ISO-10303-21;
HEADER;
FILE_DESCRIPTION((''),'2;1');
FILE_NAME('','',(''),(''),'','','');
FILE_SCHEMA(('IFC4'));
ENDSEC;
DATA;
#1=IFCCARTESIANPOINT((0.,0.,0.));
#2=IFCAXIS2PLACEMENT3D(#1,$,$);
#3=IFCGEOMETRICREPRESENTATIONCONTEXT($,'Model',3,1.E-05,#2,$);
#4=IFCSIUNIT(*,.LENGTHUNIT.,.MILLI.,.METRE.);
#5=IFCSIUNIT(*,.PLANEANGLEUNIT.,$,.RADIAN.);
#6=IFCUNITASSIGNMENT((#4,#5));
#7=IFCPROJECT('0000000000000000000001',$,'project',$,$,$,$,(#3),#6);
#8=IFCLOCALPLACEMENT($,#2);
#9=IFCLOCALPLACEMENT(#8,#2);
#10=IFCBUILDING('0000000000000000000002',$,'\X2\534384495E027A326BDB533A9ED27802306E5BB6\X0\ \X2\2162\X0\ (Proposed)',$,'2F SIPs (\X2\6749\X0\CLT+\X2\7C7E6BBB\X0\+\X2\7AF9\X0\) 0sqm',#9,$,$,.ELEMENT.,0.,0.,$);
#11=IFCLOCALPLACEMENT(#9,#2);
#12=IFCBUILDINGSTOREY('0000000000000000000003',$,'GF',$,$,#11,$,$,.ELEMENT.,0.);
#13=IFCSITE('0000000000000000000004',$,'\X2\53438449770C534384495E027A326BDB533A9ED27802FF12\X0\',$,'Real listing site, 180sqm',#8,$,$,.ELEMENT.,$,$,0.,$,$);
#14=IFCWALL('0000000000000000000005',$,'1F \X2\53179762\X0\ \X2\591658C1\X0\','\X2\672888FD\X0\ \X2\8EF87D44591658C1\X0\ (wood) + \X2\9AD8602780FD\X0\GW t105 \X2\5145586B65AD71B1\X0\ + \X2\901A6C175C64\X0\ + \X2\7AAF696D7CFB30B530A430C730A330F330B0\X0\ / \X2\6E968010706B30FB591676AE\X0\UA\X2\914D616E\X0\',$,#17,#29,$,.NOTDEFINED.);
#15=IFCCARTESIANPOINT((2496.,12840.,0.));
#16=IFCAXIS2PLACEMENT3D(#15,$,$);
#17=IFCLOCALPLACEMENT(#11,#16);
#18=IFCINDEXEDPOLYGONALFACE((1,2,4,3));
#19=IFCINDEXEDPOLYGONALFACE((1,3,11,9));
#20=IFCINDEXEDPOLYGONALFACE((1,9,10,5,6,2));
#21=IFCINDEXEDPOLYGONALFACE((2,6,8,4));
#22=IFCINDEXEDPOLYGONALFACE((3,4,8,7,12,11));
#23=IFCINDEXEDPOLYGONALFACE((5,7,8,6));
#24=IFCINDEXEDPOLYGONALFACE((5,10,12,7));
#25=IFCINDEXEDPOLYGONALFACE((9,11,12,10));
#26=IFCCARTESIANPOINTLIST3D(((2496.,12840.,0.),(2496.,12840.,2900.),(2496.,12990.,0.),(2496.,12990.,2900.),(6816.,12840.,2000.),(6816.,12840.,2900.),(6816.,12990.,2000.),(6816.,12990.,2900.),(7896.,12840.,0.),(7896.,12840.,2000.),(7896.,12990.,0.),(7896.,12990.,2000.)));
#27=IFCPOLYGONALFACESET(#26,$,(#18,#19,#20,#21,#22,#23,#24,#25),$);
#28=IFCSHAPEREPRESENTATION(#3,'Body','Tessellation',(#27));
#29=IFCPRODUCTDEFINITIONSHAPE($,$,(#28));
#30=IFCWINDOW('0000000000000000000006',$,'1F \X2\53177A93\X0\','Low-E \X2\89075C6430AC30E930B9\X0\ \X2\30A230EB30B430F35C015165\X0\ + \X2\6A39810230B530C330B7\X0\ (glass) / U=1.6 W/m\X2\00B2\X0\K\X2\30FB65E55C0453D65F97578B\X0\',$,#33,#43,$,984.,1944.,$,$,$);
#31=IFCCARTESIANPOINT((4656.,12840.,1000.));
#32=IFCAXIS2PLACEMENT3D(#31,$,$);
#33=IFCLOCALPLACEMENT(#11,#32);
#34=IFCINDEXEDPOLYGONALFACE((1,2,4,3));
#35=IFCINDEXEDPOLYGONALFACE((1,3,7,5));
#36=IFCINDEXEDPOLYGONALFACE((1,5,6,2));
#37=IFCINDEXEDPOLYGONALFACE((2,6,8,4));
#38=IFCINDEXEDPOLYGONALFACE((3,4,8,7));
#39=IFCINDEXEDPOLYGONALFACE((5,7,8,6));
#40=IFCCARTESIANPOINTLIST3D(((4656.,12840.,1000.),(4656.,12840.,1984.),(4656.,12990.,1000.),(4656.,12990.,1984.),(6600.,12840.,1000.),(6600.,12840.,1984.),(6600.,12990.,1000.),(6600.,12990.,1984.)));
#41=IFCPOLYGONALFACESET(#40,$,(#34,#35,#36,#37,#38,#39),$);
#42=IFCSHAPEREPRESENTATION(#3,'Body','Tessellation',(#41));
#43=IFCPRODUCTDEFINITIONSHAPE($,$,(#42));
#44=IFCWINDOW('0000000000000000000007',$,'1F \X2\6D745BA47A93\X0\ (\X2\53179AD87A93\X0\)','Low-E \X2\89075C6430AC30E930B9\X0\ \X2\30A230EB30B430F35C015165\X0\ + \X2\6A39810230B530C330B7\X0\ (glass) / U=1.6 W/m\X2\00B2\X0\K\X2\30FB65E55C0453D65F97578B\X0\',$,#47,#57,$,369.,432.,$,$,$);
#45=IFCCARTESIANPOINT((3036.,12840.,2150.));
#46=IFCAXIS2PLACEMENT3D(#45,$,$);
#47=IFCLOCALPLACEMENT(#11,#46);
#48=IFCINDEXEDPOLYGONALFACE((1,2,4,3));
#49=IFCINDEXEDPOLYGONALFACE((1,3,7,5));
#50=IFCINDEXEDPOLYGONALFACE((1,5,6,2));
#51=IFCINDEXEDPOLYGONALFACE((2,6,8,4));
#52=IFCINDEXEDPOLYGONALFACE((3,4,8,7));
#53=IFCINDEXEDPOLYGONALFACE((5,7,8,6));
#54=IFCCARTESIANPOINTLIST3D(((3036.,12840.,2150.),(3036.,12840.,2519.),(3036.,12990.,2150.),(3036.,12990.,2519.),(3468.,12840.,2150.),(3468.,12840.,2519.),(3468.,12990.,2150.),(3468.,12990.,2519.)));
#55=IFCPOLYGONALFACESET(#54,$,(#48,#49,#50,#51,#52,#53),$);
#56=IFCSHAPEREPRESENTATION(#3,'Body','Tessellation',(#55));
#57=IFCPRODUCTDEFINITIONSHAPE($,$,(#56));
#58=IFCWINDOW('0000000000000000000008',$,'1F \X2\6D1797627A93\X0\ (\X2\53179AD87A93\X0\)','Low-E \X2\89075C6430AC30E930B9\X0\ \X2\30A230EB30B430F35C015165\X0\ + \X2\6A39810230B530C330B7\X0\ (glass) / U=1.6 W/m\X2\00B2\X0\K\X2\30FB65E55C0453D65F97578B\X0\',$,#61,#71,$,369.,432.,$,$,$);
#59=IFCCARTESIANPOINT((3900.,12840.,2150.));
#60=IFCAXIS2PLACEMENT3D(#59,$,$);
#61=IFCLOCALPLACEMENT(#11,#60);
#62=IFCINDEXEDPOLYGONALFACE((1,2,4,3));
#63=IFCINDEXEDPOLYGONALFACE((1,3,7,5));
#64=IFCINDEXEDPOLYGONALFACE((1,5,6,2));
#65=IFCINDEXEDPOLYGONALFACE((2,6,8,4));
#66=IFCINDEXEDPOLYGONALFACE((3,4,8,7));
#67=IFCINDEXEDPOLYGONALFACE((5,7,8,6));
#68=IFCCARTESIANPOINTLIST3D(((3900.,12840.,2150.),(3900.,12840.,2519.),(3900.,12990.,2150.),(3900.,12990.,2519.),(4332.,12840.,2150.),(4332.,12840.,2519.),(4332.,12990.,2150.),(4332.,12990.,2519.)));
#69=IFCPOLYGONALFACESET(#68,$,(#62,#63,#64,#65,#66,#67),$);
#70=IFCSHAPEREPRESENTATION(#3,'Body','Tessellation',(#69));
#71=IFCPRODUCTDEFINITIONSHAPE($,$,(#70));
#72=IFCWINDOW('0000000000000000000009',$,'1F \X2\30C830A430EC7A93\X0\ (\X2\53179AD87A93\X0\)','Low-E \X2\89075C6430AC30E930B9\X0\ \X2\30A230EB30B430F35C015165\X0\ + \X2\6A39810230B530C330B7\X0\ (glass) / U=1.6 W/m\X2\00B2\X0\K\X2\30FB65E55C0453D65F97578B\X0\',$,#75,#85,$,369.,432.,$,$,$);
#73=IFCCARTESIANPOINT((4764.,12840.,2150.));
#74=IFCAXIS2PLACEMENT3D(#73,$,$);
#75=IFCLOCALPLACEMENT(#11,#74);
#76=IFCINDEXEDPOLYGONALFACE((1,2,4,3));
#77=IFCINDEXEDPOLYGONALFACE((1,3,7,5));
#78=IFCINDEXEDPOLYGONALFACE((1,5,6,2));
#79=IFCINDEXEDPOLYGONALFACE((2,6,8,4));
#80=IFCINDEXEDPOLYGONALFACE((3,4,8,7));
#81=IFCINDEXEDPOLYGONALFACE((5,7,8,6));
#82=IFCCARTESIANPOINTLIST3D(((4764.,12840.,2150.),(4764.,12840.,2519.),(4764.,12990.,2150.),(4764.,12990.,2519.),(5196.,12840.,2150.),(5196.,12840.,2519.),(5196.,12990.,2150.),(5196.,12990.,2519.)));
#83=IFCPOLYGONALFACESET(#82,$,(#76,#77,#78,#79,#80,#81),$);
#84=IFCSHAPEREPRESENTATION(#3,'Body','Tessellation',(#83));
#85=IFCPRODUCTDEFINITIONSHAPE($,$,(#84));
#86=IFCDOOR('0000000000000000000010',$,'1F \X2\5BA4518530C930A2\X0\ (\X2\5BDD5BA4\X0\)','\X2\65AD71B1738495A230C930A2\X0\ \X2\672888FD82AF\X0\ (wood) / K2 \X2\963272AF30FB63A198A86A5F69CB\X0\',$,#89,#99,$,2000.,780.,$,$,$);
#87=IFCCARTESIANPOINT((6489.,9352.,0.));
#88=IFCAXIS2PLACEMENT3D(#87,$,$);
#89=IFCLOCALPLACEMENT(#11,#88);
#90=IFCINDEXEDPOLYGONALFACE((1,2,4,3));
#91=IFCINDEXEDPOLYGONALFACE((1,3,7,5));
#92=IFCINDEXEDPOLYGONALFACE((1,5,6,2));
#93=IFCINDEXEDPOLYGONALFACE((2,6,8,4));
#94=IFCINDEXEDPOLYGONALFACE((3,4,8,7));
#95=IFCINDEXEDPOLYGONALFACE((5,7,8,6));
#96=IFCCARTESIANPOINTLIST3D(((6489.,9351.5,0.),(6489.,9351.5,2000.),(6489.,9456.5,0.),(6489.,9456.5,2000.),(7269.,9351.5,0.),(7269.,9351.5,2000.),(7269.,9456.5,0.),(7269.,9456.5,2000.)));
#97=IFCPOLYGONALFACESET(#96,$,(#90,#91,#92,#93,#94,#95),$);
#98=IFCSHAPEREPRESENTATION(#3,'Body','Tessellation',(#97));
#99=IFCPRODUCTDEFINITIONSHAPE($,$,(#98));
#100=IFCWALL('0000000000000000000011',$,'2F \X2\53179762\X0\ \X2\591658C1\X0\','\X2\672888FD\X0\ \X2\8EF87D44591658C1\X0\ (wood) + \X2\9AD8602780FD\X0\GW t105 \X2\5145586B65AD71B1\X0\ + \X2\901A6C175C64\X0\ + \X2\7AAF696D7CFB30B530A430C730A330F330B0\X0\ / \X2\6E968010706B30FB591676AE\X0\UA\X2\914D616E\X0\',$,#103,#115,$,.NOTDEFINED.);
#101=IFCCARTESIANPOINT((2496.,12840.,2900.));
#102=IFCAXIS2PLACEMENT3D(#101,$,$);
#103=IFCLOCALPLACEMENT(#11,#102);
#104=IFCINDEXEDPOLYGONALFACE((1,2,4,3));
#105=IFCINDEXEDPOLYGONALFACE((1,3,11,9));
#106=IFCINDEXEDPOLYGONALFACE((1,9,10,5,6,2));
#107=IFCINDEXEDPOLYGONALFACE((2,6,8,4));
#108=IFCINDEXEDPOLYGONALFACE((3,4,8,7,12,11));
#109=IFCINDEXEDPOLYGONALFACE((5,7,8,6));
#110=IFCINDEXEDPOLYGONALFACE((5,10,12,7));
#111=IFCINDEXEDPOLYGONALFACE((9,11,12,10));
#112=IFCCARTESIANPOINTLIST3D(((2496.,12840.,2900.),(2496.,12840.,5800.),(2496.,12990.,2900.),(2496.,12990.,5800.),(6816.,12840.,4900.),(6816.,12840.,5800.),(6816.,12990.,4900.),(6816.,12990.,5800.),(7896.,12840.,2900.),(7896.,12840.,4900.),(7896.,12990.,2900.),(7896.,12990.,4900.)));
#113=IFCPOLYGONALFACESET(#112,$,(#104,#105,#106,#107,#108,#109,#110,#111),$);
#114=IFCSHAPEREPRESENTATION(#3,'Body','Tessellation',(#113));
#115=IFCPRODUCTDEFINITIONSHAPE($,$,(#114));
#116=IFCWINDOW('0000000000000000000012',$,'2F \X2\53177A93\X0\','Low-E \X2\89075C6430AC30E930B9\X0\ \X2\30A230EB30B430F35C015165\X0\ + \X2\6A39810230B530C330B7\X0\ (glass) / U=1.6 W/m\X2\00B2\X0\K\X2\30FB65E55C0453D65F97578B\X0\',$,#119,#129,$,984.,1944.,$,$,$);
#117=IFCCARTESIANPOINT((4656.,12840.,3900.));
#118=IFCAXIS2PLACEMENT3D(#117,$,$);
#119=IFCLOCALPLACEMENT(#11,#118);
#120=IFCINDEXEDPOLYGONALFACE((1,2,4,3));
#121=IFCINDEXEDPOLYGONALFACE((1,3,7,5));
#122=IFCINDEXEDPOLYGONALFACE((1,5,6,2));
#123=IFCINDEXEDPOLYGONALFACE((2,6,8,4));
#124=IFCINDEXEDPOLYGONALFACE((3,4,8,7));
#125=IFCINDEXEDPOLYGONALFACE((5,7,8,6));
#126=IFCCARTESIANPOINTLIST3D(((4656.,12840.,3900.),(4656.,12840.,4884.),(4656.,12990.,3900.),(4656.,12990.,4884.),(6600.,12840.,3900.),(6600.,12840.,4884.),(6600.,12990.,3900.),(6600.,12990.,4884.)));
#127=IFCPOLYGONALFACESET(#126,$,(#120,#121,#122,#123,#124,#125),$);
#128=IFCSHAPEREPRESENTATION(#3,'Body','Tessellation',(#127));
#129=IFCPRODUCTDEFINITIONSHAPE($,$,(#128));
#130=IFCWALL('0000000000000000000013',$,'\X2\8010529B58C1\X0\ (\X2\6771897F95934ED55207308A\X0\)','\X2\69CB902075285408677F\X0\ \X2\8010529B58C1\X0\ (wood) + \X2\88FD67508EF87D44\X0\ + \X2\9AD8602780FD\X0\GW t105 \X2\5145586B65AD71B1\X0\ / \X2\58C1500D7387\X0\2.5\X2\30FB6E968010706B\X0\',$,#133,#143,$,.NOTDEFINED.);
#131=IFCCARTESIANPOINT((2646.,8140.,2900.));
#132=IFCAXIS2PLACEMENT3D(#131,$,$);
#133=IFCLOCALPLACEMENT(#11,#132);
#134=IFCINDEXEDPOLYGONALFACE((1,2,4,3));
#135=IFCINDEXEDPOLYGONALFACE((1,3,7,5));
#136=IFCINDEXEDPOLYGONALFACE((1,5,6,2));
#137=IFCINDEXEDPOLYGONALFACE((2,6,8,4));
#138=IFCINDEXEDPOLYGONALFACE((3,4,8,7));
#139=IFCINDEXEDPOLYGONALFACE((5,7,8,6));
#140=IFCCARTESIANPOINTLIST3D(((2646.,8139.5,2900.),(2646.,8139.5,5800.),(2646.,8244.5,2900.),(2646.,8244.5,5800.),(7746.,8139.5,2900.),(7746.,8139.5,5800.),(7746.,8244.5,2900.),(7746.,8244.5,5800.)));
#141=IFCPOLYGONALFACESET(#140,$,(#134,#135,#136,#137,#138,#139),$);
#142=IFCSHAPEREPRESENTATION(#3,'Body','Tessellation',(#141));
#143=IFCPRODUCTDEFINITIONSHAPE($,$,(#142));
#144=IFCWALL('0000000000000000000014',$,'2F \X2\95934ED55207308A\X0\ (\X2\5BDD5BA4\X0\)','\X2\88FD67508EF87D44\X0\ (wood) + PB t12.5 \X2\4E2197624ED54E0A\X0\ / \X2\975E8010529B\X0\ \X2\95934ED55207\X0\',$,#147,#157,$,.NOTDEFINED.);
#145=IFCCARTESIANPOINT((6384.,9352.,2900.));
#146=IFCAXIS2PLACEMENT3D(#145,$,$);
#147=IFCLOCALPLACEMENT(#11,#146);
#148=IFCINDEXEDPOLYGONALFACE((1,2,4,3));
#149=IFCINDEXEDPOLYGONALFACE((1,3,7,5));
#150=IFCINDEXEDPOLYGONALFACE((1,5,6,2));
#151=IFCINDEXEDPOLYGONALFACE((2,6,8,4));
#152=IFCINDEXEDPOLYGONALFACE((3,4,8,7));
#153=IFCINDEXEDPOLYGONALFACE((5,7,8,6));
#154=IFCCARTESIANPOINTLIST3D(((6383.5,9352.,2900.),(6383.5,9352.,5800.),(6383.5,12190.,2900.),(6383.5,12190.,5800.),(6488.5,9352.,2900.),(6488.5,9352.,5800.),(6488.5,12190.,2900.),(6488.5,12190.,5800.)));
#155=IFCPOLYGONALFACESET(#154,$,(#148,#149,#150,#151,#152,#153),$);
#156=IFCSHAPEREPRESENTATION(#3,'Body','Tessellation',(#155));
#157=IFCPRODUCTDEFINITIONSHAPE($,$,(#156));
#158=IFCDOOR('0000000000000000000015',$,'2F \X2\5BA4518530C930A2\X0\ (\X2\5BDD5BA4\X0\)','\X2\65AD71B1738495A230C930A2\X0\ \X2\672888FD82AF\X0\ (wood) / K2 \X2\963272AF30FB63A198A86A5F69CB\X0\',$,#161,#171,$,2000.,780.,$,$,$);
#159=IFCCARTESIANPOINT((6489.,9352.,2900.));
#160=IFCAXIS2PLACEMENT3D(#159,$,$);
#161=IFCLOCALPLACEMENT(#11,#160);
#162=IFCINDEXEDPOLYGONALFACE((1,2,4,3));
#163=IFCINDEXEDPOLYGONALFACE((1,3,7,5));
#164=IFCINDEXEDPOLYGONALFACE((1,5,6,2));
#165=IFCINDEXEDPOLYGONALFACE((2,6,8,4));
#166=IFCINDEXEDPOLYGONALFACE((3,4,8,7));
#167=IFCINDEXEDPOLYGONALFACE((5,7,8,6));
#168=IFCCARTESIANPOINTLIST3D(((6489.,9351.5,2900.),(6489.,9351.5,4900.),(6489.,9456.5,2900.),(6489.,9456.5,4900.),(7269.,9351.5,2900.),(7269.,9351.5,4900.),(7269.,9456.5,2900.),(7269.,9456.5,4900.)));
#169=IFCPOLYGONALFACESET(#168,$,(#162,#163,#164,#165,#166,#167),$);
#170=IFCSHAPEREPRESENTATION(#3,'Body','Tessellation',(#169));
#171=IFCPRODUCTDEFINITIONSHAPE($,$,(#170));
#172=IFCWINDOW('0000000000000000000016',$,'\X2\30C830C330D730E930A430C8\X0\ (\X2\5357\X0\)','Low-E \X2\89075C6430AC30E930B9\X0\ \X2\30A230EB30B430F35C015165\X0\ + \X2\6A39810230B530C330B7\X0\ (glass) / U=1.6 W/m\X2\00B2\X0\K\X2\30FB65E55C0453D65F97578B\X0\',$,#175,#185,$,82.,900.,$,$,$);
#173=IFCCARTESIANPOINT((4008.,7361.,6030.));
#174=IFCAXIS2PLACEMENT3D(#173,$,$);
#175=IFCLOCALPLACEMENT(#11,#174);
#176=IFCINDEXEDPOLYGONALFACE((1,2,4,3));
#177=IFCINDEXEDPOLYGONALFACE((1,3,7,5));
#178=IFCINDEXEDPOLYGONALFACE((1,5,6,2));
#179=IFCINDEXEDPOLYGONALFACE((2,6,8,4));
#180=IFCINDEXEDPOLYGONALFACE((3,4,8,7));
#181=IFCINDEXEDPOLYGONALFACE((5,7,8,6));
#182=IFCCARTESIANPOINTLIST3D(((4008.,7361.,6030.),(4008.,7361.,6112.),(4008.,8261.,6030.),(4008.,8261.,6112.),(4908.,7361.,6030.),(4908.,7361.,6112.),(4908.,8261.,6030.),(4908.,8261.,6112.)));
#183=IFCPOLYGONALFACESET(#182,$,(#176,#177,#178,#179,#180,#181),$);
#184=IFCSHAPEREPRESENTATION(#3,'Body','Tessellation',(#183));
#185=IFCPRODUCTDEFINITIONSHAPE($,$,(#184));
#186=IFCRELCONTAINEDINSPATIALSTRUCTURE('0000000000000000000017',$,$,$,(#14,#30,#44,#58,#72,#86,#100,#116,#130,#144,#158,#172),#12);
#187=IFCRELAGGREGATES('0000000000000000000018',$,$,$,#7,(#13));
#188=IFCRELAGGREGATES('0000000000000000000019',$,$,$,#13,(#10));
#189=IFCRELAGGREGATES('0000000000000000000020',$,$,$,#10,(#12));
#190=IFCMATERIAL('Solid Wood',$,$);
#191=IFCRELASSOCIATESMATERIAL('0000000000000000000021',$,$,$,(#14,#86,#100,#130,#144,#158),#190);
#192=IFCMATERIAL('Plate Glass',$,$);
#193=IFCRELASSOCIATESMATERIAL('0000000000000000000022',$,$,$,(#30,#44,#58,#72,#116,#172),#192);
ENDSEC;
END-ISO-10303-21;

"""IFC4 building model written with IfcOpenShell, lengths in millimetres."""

from ifc_helpers import new_model, si_unit, frame, frame_2d, origin, place, context, project, spatial, rectangle, extrude, material, element, fill, save


model = new_model("IFC4")

# Units and contexts
model_context = context("Model", 3, precision=1e-05, world=origin())
ifc_project = project(units=[si_unit("LENGTHUNIT", "METRE", prefix="MILLI"), si_unit("PLANEANGLEUNIT", "RADIAN")], contexts=[model_context])

# Site, building, storey
site_placement = place(None, origin())
site = spatial("IfcSite", under=ifc_project, at=site_placement, Name="千葉県千葉市稲毛区黒砂２", ObjectType="Real listing site, 180sqm", CompositionType="ELEMENT", RefElevation=0.0)
building_placement = place(site_placement, origin())
building = spatial("IfcBuilding", under=site, at=building_placement, Name="千葉市稲毛区黒砂の家 Ⅲ (Proposed)", ObjectType="2F SIPs (杉CLT+籾殻+竹) 0sqm", CompositionType="ELEMENT", ElevationOfRefHeight=0.0, ElevationOfTerrain=0.0)
storey_placement = place(building_placement, origin())
storey = spatial("IfcBuildingStorey", under=building, at=storey_placement, Name="GF", CompositionType="ELEMENT", Elevation=0.0)

# Wall, openings, windows
ifc_material_1 = material(Name="Solid Wood")
wall_1_placement = place(storey_placement, frame((2496.0, 12840.0, 0.0)))
wall_1 = element("IfcWall", 1, at=wall_1_placement, inside=storey, material=ifc_material_1, Name="1F 北面 外壁", Description="木製 軸組外壁 (wood) + 高性能GW t105 充填断熱 + 通気層 + 窯業系サイディング / 準耐火・外皮UA配慮", PredefinedType="NOTDEFINED", context=model_context, shape_type="SweptSolid", body=[
    extrude(rectangle(XDim=5400.0, YDim=150.0, at=frame_2d((2700.0, 75.0))), frame((2496.0, 12840.0, 0.0)), (0.0, 0.0, 1.0), 2900.0),
])
opening_1_placement = place(storey_placement, frame((4656.0, 12840.0, 1000.0)))
opening_1 = element("IfcOpeningElement", 2, at=opening_1_placement, cuts=wall_1, PredefinedType="NOTDEFINED", context=model_context, shape_type="SweptSolid", body=[
    extrude(rectangle(XDim=1944.0, YDim=150.0, at=frame_2d((972.0, 75.0))), frame((4656.0, 12840.0, 1000.0)), (0.0, 0.0, 1.0), 984.0),
])
opening_2_placement = place(storey_placement, frame((3036.0, 12840.0, 2150.0)))
opening_2 = element("IfcOpeningElement", 3, at=opening_2_placement, cuts=wall_1, PredefinedType="NOTDEFINED", context=model_context, shape_type="SweptSolid", body=[
    extrude(rectangle(XDim=432.0, YDim=150.0, at=frame_2d((216.0, 75.0))), frame((3036.0, 12840.0, 2150.0)), (0.0, 0.0, 1.0), 369.0),
])
opening_3_placement = place(storey_placement, frame((3900.0, 12840.0, 2150.0)))
opening_3 = element("IfcOpeningElement", 4, at=opening_3_placement, cuts=wall_1, PredefinedType="NOTDEFINED", context=model_context, shape_type="SweptSolid", body=[
    extrude(rectangle(XDim=432.0, YDim=150.0, at=frame_2d((216.0, 75.0))), frame((3900.0, 12840.0, 2150.0)), (0.0, 0.0, 1.0), 369.0),
])
opening_4_placement = place(storey_placement, frame((4764.0, 12840.0, 2150.0)))
opening_4 = element("IfcOpeningElement", 5, at=opening_4_placement, cuts=wall_1, PredefinedType="NOTDEFINED", context=model_context, shape_type="SweptSolid", body=[
    extrude(rectangle(XDim=432.0, YDim=150.0, at=frame_2d((216.0, 75.0))), frame((4764.0, 12840.0, 2150.0)), (0.0, 0.0, 1.0), 369.0),
])
ifc_material_2 = material(Name="Plate Glass")
window_1_placement = place(storey_placement, frame((4656.0, 12840.0, 1000.0)))
window_1 = element("IfcWindow", 6, at=window_1_placement, inside=storey, material=ifc_material_2, Name="1F 北窓", Description="Low-E 複層ガラス アルゴン封入 + 樹脂サッシ (glass) / U=1.6 W/m²K・日射取得型", OverallHeight=984.0, OverallWidth=1944.0, context=model_context, shape_type="SweptSolid", body=[
    extrude(rectangle(XDim=1944.0, YDim=150.0, at=frame_2d((972.0, 75.0))), frame((4656.0, 12840.0, 1000.0)), (0.0, 0.0, 1.0), 984.0),
])
fill(opening_1, window_1)
window_2_placement = place(storey_placement, frame((3036.0, 12840.0, 2150.0)))
window_2 = element("IfcWindow", 7, at=window_2_placement, inside=storey, material=ifc_material_2, Name="1F 浴室窓 (北高窓)", Description="Low-E 複層ガラス アルゴン封入 + 樹脂サッシ (glass) / U=1.6 W/m²K・日射取得型", OverallHeight=369.0, OverallWidth=432.0, context=model_context, shape_type="SweptSolid", body=[
    extrude(rectangle(XDim=432.0, YDim=150.0, at=frame_2d((216.0, 75.0))), frame((3036.0, 12840.0, 2150.0)), (0.0, 0.0, 1.0), 369.0),
])
fill(opening_2, window_2)
window_3_placement = place(storey_placement, frame((3900.0, 12840.0, 2150.0)))
window_3 = element("IfcWindow", 8, at=window_3_placement, inside=storey, material=ifc_material_2, Name="1F 洗面窓 (北高窓)", Description="Low-E 複層ガラス アルゴン封入 + 樹脂サッシ (glass) / U=1.6 W/m²K・日射取得型", OverallHeight=369.0, OverallWidth=432.0, context=model_context, shape_type="SweptSolid", body=[
    extrude(rectangle(XDim=432.0, YDim=150.0, at=frame_2d((216.0, 75.0))), frame((3900.0, 12840.0, 2150.0)), (0.0, 0.0, 1.0), 369.0),
])
fill(opening_3, window_3)
window_4_placement = place(storey_placement, frame((4764.0, 12840.0, 2150.0)))
window_4 = element("IfcWindow", 9, at=window_4_placement, inside=storey, material=ifc_material_2, Name="1F トイレ窓 (北高窓)", Description="Low-E 複層ガラス アルゴン封入 + 樹脂サッシ (glass) / U=1.6 W/m²K・日射取得型", OverallHeight=369.0, OverallWidth=432.0, context=model_context, shape_type="SweptSolid", body=[
    extrude(rectangle(XDim=432.0, YDim=150.0, at=frame_2d((216.0, 75.0))), frame((4764.0, 12840.0, 2150.0)), (0.0, 0.0, 1.0), 369.0),
])
fill(opening_4, window_4)

# Door
door_1_placement = place(storey_placement, frame((6489.0, 9352.0, 0.0)))
element("IfcDoor", 10, at=door_1_placement, inside=storey, material=ifc_material_1, Name="1F 室内ドア (寝室)", Description="断熱玄関ドア 木製芯 (wood) / K2 防犯・採風機構", OverallHeight=2000.0, OverallWidth=780.0, context=model_context, shape_type="SweptSolid", body=[
    extrude(rectangle(XDim=780.0, YDim=105.0, at=frame_2d((390.0, 52.0))), frame((6489.0, 9352.0, 0.0)), (0.0, 0.0, 1.0), 2000.0),
])

# Wall, opening, window
wall_2_placement = place(storey_placement, frame((2496.0, 12840.0, 2900.0)))
wall_2 = element("IfcWall", 11, at=wall_2_placement, inside=storey, material=ifc_material_1, Name="2F 北面 外壁", Description="木製 軸組外壁 (wood) + 高性能GW t105 充填断熱 + 通気層 + 窯業系サイディング / 準耐火・外皮UA配慮", PredefinedType="NOTDEFINED", context=model_context, shape_type="SweptSolid", body=[
    extrude(rectangle(XDim=5400.0, YDim=150.0, at=frame_2d((2700.0, 75.0))), frame((2496.0, 12840.0, 2900.0)), (0.0, 0.0, 1.0), 2900.0),
])
opening_5_placement = place(storey_placement, frame((4656.0, 12840.0, 3900.0)))
opening_5 = element("IfcOpeningElement", 12, at=opening_5_placement, cuts=wall_2, PredefinedType="NOTDEFINED", context=model_context, shape_type="SweptSolid", body=[
    extrude(rectangle(XDim=1944.0, YDim=150.0, at=frame_2d((972.0, 75.0))), frame((4656.0, 12840.0, 3900.0)), (0.0, 0.0, 1.0), 984.0),
])
window_5_placement = place(storey_placement, frame((4656.0, 12840.0, 3900.0)))
window_5 = element("IfcWindow", 13, at=window_5_placement, inside=storey, material=ifc_material_2, Name="2F 北窓", Description="Low-E 複層ガラス アルゴン封入 + 樹脂サッシ (glass) / U=1.6 W/m²K・日射取得型", OverallHeight=984.0, OverallWidth=1944.0, context=model_context, shape_type="SweptSolid", body=[
    extrude(rectangle(XDim=1944.0, YDim=150.0, at=frame_2d((972.0, 75.0))), frame((4656.0, 12840.0, 3900.0)), (0.0, 0.0, 1.0), 984.0),
])
fill(opening_5, window_5)

# Walls
wall_3_placement = place(storey_placement, frame((2646.0, 8140.0, 2900.0)))
element("IfcWall", 14, at=wall_3_placement, inside=storey, material=ifc_material_1, Name="耐力壁 (東西間仕切り)", Description="構造用合板 耐力壁 (wood) + 製材軸組 + 高性能GW t105 充填断熱 / 壁倍率2.5・準耐火", PredefinedType="NOTDEFINED", context=model_context, shape_type="SweptSolid", body=[
    extrude(rectangle(XDim=5100.0, YDim=105.0, at=frame_2d((2550.0, 52.0))), frame((2646.0, 8140.0, 2900.0)), (0.0, 0.0, 1.0), 2900.0),
])
wall_4_placement = place(storey_placement, frame((6384.0, 9352.0, 2900.0)))
element("IfcWall", 15, at=wall_4_placement, inside=storey, material=ifc_material_1, Name="2F 間仕切り (寝室)", Description="製材軸組 (wood) + PB t12.5 両面仕上 / 非耐力 間仕切", PredefinedType="NOTDEFINED", context=model_context, shape_type="SweptSolid", body=[
    extrude(rectangle(XDim=105.0, YDim=2838.0, at=frame_2d((52.0, 1419.0))), frame((6384.0, 9352.0, 2900.0)), (0.0, 0.0, 1.0), 2900.0),
])

# Door
door_2_placement = place(storey_placement, frame((6489.0, 9352.0, 2900.0)))
element("IfcDoor", 16, at=door_2_placement, inside=storey, material=ifc_material_1, Name="2F 室内ドア (寝室)", Description="断熱玄関ドア 木製芯 (wood) / K2 防犯・採風機構", OverallHeight=2000.0, OverallWidth=780.0, context=model_context, shape_type="SweptSolid", body=[
    extrude(rectangle(XDim=780.0, YDim=105.0, at=frame_2d((390.0, 52.0))), frame((6489.0, 9352.0, 2900.0)), (0.0, 0.0, 1.0), 2000.0),
])

# Window
window_6_placement = place(storey_placement, frame((4008.0, 7361.0, 6030.0)))
element("IfcWindow", 17, at=window_6_placement, inside=storey, material=ifc_material_2, Name="トップライト (南)", Description="Low-E 複層ガラス アルゴン封入 + 樹脂サッシ (glass) / U=1.6 W/m²K・日射取得型", OverallHeight=82.0, OverallWidth=900.0, context=model_context, shape_type="SweptSolid", body=[
    extrude(rectangle(XDim=900.0, YDim=900.0, at=frame_2d((450.0, 450.0))), frame((4008.0, 7361.0, 6030.0)), (0.0, 0.0, 1.0), 82.0),
])

save(model, "model.ifc")
